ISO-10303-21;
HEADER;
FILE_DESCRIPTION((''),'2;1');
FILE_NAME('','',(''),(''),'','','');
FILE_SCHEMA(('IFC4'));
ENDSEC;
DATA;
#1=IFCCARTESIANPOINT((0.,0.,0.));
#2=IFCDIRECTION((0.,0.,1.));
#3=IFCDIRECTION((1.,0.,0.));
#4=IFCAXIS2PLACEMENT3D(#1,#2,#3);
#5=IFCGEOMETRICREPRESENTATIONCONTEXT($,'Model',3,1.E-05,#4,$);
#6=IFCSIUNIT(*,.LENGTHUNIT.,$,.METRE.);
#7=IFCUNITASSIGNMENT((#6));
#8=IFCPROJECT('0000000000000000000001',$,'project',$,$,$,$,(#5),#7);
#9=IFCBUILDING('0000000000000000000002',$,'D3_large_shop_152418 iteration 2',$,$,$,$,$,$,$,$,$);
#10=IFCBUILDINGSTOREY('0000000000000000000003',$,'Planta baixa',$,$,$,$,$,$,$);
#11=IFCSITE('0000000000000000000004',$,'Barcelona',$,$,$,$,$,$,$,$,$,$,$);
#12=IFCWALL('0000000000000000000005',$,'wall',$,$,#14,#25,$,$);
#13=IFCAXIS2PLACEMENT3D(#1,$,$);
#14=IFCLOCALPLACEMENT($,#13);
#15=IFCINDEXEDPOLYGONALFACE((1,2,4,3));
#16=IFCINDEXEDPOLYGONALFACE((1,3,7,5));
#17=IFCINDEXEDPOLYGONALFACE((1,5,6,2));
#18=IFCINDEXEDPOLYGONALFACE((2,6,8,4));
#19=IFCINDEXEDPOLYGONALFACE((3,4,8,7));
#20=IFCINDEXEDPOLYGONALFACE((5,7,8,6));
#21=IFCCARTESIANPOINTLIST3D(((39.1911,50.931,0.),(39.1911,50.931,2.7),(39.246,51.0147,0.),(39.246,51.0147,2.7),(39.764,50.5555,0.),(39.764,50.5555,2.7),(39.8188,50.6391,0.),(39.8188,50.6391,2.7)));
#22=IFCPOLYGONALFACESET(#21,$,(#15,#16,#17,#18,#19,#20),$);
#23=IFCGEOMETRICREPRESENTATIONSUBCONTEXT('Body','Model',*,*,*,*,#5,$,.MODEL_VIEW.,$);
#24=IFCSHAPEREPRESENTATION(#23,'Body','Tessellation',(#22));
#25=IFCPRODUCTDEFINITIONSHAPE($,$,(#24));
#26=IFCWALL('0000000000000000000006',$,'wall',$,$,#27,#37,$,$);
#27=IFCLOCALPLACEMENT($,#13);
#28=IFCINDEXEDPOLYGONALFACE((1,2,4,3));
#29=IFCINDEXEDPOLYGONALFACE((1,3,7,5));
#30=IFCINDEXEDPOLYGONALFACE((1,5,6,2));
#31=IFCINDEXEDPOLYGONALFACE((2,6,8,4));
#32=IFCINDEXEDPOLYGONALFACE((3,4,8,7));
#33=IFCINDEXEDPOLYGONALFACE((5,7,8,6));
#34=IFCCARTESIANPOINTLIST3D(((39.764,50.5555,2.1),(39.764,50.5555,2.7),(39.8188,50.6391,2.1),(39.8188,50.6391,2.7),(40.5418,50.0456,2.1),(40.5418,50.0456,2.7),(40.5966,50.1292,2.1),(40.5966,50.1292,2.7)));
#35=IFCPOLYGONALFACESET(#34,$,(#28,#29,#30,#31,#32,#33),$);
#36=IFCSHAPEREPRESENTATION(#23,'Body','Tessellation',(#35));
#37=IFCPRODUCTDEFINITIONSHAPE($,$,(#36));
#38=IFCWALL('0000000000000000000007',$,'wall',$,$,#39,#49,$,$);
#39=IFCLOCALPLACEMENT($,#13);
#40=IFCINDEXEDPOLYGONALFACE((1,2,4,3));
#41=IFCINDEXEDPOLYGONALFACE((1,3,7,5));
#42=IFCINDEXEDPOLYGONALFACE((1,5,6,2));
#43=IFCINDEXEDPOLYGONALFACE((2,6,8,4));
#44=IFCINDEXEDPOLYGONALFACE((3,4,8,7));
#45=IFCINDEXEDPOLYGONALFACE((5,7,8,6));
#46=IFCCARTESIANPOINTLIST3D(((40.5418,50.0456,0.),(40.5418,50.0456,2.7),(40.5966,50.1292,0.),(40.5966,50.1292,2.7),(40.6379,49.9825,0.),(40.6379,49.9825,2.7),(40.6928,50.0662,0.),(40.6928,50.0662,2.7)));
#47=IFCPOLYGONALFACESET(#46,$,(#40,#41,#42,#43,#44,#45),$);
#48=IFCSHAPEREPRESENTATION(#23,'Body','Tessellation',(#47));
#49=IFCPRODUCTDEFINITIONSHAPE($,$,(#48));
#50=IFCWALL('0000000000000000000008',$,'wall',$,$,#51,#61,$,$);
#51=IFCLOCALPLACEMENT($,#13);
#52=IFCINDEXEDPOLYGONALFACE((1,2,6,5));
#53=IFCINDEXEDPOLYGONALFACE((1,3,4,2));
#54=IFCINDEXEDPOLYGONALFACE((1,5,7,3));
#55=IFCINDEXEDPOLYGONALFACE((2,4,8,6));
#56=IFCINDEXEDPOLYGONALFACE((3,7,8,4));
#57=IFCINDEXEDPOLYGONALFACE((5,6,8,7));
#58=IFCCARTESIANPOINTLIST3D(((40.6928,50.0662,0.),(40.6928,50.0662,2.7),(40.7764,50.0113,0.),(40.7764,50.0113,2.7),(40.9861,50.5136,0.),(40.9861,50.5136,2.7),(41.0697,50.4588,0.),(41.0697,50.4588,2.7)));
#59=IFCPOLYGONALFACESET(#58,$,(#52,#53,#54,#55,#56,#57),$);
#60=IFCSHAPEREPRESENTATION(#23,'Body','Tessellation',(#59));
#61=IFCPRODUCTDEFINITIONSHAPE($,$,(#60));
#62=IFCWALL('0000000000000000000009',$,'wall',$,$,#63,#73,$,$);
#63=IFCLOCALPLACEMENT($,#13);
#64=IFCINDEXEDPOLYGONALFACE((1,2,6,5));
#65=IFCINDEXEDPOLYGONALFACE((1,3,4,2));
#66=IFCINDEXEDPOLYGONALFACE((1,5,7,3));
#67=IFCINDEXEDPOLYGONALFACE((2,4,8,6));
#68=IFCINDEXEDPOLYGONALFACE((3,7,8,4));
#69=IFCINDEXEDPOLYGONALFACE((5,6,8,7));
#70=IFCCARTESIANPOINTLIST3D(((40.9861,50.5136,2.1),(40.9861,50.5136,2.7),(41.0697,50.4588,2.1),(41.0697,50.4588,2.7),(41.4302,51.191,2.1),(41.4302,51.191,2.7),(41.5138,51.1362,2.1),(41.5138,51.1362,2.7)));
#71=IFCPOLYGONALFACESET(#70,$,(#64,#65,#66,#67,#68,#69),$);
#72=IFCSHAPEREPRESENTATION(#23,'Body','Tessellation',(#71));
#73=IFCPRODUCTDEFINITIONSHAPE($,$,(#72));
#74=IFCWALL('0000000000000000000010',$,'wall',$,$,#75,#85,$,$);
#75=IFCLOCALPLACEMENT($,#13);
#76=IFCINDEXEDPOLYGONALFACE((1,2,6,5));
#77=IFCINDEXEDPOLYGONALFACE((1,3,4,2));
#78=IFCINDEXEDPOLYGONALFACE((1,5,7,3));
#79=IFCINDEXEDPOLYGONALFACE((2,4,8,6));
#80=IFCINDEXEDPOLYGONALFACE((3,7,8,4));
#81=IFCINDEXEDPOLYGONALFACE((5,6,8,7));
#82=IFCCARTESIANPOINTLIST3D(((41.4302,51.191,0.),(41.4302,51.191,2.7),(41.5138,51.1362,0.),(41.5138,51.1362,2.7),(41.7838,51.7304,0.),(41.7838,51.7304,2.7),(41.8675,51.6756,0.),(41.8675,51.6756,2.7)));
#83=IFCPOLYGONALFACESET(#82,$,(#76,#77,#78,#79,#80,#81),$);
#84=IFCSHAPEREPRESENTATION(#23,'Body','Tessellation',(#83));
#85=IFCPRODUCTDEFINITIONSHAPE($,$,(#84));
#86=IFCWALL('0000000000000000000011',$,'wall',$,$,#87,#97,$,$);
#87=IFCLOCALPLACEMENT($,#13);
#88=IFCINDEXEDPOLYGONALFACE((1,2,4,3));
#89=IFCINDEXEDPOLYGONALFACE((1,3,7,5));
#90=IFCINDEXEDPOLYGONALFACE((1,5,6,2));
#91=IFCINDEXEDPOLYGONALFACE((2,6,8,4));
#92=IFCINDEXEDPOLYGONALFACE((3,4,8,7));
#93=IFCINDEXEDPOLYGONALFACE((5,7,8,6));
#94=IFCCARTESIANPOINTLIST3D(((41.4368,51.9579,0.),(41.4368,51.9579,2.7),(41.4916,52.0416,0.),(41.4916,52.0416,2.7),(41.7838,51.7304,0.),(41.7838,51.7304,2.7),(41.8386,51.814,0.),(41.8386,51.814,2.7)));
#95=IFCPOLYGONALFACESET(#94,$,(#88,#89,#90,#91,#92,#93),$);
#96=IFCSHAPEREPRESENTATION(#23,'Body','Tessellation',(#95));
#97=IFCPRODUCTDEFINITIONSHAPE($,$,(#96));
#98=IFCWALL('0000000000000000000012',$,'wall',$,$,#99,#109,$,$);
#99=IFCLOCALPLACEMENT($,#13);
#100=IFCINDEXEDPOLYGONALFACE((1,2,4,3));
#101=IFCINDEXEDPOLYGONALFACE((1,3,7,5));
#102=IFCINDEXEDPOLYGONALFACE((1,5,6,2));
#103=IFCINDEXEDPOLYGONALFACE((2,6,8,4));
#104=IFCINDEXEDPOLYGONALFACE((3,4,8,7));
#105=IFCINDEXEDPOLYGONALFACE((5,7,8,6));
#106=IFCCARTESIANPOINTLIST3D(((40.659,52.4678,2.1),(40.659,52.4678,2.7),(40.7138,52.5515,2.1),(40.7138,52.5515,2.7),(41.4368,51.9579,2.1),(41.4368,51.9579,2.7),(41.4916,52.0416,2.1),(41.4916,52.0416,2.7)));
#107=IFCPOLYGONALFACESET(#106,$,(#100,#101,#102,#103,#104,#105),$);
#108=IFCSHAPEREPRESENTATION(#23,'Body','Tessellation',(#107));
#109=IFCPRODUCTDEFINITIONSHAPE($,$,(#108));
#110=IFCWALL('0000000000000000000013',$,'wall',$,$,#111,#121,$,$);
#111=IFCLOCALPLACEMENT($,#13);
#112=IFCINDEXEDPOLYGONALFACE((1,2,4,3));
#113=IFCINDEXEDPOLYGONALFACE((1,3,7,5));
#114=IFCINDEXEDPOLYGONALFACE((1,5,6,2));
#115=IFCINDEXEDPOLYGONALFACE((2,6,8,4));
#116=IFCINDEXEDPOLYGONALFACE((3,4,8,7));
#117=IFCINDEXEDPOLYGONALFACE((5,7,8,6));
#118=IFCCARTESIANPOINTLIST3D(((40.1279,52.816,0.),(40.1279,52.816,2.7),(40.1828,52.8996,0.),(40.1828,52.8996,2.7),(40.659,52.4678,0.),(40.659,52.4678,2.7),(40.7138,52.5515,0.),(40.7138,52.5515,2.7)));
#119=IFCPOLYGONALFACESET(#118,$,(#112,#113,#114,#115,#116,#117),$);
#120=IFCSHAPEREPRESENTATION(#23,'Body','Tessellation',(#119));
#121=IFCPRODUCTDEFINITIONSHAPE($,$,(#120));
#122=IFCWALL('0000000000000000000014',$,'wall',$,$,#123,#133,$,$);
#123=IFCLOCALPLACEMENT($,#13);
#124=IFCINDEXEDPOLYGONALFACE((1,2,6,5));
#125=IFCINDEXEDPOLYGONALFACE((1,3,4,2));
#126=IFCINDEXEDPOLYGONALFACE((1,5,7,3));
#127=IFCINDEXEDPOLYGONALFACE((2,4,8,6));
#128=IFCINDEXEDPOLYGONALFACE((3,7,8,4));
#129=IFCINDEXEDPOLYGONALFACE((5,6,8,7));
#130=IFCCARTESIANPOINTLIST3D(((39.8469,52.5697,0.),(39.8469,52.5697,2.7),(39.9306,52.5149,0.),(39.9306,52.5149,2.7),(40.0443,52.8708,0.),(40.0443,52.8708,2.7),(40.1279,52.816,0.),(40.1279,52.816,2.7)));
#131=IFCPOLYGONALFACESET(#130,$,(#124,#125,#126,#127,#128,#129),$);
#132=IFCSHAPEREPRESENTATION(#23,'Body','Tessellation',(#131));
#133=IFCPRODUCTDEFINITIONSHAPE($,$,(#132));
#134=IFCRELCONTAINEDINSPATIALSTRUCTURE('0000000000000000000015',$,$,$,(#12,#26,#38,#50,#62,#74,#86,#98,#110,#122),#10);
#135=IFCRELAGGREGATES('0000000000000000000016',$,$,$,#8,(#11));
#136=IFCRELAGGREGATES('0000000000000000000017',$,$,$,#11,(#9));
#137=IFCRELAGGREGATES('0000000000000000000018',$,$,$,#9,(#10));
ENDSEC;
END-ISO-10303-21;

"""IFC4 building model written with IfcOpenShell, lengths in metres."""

from ifc_helpers import new_model, si_unit, frame, origin, origin_with_axes, place, context, subcontext, project, spatial, polyline, outline, extrude, element, save


model = new_model("IFC4")

# Units and contexts
model_context = context("Model", 3, precision=1e-05, world=origin_with_axes())
body_context = subcontext(model_context, "Body", "Model", "MODEL_VIEW")
ifc_project = project(units=[si_unit("LENGTHUNIT", "METRE")], contexts=[model_context])

# Site, building, storey
site = spatial("IfcSite", under=ifc_project, Name="Barcelona")
building = spatial("IfcBuilding", under=site, Name="D3_large_shop_152418 iteration 2")
storey = spatial("IfcBuildingStorey", under=building, Name="Planta baixa")

# Walls
wall_1_placement = place(None, origin_with_axes())
element("IfcWall", 1, at=wall_1_placement, inside=storey, Name="wall", context=body_context, shape_type="SweptSolid", body=[
    extrude(outline(polyline([(39.246, 51.0147), (39.8188, 50.6391), (39.764, 50.5555), (39.1911, 50.931), (39.246, 51.0147)])), origin(), (0.0, 0.0, 1.0), 2.7),
])
wall_2_placement = place(None, origin_with_axes())
element("IfcWall", 2, at=wall_2_placement, inside=storey, Name="wall", context=body_context, shape_type="SweptSolid", body=[
    extrude(outline(polyline([(39.8188, 50.6391), (40.5966, 50.1292), (40.5418, 50.0456), (39.764, 50.5555), (39.8188, 50.6391)])), frame((0.0, 0.0, 2.1)), (0.0, 0.0, 1.0), 0.6),
])
wall_3_placement = place(None, origin_with_axes())
element("IfcWall", 3, at=wall_3_placement, inside=storey, Name="wall", context=body_context, shape_type="SweptSolid", body=[
    extrude(outline(polyline([(40.5966, 50.1292), (40.6928, 50.0662), (40.6379, 49.9825), (40.5418, 50.0456), (40.5966, 50.1292)])), origin(), (0.0, 0.0, 1.0), 2.7),
])
wall_4_placement = place(None, origin_with_axes())
element("IfcWall", 4, at=wall_4_placement, inside=storey, Name="wall", context=body_context, shape_type="SweptSolid", body=[
    extrude(outline(polyline([(40.6928, 50.0662), (40.9861, 50.5136), (41.0697, 50.4588), (40.7764, 50.0113), (40.6928, 50.0662)])), origin(), (0.0, 0.0, 1.0), 2.7),
])
wall_5_placement = place(None, origin_with_axes())
element("IfcWall", 5, at=wall_5_placement, inside=storey, Name="wall", context=body_context, shape_type="SweptSolid", body=[
    extrude(outline(polyline([(40.9861, 50.5136), (41.4302, 51.191), (41.5138, 51.1362), (41.0697, 50.4588), (40.9861, 50.5136)])), frame((0.0, 0.0, 2.1)), (0.0, 0.0, 1.0), 0.6),
])
wall_6_placement = place(None, origin_with_axes())
element("IfcWall", 6, at=wall_6_placement, inside=storey, Name="wall", context=body_context, shape_type="SweptSolid", body=[
    extrude(outline(polyline([(41.4302, 51.191), (41.7838, 51.7304), (41.8675, 51.6756), (41.5138, 51.1362), (41.4302, 51.191)])), origin(), (0.0, 0.0, 1.0), 2.7),
])
wall_7_placement = place(None, origin_with_axes())
element("IfcWall", 7, at=wall_7_placement, inside=storey, Name="wall", context=body_context, shape_type="SweptSolid", body=[
    extrude(outline(polyline([(41.7838, 51.7304), (41.4368, 51.9579), (41.4916, 52.0416), (41.8386, 51.814), (41.7838, 51.7304)])), origin(), (0.0, 0.0, 1.0), 2.7),
])
wall_8_placement = place(None, origin_with_axes())
element("IfcWall", 8, at=wall_8_placement, inside=storey, Name="wall", context=body_context, shape_type="SweptSolid", body=[
    extrude(outline(polyline([(41.4368, 51.9579), (40.659, 52.4678), (40.7138, 52.5515), (41.4916, 52.0416), (41.4368, 51.9579)])), frame((0.0, 0.0, 2.1)), (0.0, 0.0, 1.0), 0.6),
])
wall_9_placement = place(None, origin_with_axes())
element("IfcWall", 9, at=wall_9_placement, inside=storey, Name="wall", context=body_context, shape_type="SweptSolid", body=[
    extrude(outline(polyline([(40.659, 52.4678), (40.1279, 52.816), (40.1828, 52.8996), (40.7138, 52.5515), (40.659, 52.4678)])), origin(), (0.0, 0.0, 1.0), 2.7),
])
wall_10_placement = place(None, origin_with_axes())
element("IfcWall", 10, at=wall_10_placement, inside=storey, Name="wall", context=body_context, shape_type="SweptSolid", body=[
    extrude(outline(polyline([(40.1279, 52.816), (39.9306, 52.5149), (39.8469, 52.5697), (40.0443, 52.8708), (40.1279, 52.816)])), origin(), (0.0, 0.0, 1.0), 2.7),
])

save(model, "model.ifc")
